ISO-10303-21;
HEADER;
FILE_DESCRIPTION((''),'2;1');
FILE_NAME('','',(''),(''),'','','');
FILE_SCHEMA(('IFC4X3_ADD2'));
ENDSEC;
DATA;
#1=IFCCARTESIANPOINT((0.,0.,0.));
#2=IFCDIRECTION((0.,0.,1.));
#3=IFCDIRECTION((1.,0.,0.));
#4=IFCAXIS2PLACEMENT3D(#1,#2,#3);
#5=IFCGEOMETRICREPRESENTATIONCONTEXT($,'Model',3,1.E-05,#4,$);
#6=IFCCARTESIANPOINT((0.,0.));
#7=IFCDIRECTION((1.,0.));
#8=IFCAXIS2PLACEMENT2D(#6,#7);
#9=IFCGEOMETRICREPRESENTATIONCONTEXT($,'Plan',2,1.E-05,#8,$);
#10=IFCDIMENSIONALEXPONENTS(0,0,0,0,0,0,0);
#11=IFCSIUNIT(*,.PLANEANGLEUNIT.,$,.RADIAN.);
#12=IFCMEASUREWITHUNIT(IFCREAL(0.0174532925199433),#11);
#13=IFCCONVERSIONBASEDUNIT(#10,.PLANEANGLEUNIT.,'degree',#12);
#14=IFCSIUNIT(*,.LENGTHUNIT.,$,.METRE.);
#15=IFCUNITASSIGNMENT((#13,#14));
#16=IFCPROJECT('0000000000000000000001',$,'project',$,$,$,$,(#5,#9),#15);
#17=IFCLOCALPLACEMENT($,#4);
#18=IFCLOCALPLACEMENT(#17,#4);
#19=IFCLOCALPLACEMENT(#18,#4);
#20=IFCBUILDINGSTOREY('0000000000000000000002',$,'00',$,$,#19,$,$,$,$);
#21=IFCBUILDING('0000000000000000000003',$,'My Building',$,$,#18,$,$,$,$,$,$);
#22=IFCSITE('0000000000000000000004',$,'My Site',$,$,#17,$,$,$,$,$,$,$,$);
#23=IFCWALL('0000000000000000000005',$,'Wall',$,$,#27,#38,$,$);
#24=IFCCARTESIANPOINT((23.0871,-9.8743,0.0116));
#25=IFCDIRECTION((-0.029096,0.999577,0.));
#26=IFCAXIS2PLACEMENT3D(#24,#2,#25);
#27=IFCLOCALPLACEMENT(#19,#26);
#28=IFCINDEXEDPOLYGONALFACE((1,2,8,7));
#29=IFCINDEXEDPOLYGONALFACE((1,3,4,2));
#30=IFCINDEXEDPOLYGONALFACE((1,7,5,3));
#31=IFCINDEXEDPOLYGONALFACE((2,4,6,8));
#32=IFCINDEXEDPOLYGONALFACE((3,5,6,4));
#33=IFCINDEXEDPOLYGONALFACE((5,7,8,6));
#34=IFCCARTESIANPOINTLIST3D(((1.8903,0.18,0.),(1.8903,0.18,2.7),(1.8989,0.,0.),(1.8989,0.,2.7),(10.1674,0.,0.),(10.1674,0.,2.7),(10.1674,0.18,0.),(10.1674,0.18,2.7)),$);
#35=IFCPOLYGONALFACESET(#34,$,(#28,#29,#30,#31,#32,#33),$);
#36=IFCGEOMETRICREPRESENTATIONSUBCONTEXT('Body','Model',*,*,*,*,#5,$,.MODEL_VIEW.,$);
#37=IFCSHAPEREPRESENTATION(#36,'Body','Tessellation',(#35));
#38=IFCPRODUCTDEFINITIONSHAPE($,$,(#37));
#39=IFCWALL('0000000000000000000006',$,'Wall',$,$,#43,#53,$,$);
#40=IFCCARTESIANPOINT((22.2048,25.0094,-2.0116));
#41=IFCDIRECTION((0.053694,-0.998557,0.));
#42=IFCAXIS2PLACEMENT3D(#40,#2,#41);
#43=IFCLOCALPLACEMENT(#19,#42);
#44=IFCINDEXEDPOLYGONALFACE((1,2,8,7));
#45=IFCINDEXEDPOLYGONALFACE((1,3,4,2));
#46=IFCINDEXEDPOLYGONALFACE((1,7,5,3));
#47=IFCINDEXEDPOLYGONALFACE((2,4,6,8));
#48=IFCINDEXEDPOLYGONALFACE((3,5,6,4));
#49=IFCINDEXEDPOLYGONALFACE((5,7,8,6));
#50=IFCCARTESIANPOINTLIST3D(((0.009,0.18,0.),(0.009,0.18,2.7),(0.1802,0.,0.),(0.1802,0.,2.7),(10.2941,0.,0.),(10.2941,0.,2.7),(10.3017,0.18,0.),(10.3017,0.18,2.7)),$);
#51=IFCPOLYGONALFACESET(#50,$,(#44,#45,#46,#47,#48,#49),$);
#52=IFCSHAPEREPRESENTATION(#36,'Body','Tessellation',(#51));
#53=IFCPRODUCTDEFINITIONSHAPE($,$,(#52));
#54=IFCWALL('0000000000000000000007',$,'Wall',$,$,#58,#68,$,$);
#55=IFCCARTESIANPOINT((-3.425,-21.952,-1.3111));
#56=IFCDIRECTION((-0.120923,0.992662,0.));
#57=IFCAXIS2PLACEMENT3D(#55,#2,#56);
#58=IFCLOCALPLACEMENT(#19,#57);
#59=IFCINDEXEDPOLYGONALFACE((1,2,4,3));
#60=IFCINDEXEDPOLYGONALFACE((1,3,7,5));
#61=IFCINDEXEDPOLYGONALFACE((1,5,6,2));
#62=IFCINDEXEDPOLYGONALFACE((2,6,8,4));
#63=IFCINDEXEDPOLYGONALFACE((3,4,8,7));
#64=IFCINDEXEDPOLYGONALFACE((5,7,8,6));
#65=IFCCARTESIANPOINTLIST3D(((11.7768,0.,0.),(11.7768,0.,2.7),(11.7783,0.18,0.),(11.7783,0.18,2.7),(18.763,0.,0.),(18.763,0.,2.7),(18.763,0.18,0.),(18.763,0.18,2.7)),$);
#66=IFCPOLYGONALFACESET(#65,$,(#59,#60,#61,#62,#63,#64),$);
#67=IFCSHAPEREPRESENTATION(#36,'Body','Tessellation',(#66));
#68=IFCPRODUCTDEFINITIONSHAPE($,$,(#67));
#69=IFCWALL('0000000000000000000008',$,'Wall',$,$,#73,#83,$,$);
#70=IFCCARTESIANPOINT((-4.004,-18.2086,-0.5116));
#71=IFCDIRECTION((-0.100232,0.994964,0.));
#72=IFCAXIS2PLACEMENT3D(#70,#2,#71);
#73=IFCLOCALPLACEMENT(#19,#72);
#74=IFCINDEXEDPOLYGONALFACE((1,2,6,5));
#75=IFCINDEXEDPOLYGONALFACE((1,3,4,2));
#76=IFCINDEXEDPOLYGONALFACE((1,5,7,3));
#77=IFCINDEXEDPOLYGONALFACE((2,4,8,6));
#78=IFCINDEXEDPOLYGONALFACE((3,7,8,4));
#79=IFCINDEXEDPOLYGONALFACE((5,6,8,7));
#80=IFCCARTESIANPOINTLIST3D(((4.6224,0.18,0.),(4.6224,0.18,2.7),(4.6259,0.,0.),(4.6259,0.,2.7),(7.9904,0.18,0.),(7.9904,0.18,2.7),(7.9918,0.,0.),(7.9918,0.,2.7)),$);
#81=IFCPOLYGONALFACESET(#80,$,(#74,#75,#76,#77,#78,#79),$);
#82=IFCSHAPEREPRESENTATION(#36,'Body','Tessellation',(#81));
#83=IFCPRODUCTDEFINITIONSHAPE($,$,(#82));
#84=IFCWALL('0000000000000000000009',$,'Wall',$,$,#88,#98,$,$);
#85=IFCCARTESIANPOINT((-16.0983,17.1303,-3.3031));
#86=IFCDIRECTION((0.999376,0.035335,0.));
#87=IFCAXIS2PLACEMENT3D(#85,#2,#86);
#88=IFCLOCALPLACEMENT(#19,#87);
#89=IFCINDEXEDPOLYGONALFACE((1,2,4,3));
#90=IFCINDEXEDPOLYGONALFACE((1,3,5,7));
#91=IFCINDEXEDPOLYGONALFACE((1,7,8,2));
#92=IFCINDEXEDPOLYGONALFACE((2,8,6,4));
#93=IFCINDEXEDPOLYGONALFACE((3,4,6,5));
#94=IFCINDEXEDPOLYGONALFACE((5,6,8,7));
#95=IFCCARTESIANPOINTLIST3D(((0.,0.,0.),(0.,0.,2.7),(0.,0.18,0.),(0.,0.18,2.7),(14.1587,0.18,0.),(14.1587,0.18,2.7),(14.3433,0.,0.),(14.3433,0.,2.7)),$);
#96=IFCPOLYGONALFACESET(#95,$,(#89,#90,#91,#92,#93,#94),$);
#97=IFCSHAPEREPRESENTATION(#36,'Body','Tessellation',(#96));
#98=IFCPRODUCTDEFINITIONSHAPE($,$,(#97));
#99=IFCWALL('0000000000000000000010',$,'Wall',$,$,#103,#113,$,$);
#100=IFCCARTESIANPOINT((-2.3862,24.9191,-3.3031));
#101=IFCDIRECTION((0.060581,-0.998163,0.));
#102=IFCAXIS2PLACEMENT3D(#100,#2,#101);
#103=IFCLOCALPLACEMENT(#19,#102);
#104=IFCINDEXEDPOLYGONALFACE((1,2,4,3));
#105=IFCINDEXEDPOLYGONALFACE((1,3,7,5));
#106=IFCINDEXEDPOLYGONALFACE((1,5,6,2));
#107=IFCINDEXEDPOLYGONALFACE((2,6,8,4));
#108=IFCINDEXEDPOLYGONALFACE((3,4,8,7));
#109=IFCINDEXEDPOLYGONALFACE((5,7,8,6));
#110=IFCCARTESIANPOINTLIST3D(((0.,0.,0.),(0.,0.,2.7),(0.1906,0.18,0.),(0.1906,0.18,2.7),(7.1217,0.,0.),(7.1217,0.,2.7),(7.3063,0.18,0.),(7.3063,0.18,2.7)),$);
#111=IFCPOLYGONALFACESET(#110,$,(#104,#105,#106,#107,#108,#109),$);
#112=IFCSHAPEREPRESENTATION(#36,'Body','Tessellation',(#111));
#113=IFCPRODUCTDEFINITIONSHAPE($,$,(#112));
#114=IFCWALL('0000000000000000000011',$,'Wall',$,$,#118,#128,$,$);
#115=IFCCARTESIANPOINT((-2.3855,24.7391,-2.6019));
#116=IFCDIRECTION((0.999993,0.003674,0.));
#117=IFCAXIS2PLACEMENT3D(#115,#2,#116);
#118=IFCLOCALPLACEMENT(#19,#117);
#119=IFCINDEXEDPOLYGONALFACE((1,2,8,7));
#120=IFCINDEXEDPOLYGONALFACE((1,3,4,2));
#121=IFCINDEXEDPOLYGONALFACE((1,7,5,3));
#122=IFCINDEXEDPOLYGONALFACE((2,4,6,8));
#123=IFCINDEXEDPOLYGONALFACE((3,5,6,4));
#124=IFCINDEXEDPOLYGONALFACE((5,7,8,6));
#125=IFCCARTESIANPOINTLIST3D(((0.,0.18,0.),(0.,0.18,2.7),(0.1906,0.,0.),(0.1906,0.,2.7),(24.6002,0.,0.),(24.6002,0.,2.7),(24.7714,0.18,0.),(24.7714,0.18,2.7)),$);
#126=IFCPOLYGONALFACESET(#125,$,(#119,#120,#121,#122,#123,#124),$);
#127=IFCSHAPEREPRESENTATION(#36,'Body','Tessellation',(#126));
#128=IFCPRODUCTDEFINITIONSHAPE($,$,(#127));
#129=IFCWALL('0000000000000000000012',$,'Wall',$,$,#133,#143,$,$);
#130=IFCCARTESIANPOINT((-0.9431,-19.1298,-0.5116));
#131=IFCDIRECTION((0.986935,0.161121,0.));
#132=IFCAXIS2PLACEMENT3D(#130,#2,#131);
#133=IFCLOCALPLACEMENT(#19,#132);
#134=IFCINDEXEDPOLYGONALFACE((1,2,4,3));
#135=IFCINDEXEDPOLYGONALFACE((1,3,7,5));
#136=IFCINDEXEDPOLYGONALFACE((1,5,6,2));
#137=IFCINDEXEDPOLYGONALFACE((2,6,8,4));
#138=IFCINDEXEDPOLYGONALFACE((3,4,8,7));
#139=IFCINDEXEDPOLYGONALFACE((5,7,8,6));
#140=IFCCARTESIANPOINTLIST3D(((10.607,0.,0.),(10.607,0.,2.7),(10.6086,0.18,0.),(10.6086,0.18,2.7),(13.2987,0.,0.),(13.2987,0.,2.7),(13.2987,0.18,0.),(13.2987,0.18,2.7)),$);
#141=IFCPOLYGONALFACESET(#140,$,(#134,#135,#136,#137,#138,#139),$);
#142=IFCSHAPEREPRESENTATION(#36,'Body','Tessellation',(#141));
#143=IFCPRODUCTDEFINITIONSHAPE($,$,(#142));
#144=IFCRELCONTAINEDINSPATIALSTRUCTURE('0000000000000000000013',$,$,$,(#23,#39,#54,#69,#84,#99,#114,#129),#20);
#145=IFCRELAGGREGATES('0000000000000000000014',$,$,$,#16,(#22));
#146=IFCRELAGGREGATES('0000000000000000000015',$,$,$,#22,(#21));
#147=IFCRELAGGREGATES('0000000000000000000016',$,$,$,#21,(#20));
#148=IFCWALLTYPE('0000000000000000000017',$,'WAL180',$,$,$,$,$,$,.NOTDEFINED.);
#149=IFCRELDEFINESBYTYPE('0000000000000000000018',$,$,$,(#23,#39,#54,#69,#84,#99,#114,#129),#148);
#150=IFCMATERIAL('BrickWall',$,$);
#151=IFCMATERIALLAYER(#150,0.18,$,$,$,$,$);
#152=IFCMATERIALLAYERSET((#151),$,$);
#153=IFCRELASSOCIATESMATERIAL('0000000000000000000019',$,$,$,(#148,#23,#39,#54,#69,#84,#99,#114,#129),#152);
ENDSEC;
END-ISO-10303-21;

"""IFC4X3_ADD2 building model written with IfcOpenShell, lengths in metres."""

from ifc_helpers import new_model, entity, si_unit, converted_unit, frame, origin_with_axes, origin_2d_with_axis, place, context, subcontext, project, spatial, indexed_curve, outline, extrude, clip, halfspace, material, layer, layer_set, layer_usage, type_object, element, save


model = new_model("IFC4X3_ADD2")

# Units and contexts
model_context = context("Model", 3, precision=1e-05, world=origin_with_axes())
plan_context = context("Plan", 2, precision=1e-05, world=origin_2d_with_axis())
body_context = subcontext(model_context, "Body", "Model", "MODEL_VIEW")
ifc_project = project(units=[converted_unit("PLANEANGLEUNIT", "degree", entity("IfcReal", 0.0174532925199433), si_unit("PLANEANGLEUNIT", "RADIAN"), dimensions=[0, 0, 0, 0, 0, 0, 0]), si_unit("LENGTHUNIT", "METRE")], contexts=[model_context, plan_context])

# Site, building, storey
site_placement = place(None, origin_with_axes())
site = spatial("IfcSite", under=ifc_project, at=site_placement, Name="My Site")
building_placement = place(site_placement, origin_with_axes())
building = spatial("IfcBuilding", under=site, at=building_placement, Name="My Building")
storey_placement = place(building_placement, origin_with_axes())
storey = spatial("IfcBuildingStorey", under=building, at=storey_placement, Name="00")

# Walls
ifc_material = material(Name="BrickWall")
ifc_layer = layer(ifc_material, 0.18)
ifc_layer_set = layer_set([ifc_layer])
wall_type = type_object("IfcWallType", Name="WAL180", PredefinedType="NOTDEFINED", material=ifc_layer_set)
ifc_layer_usage_1 = layer_usage(ifc_layer_set, "AXIS2", "POSITIVE", 0.0)
wall_1_placement = place(storey_placement, frame((23.0871, -9.8743, 0.0116), z_axis=(0.0, 0.0, 1.0), x_axis=(-0.029096, 0.999577, 0.0)))
element("IfcWall", 1, at=wall_1_placement, inside=storey, type_object=wall_type, material=ifc_layer_usage_1, Name="Wall", context=body_context, shape_type="Clipping", body=[
    clip(extrude(outline(indexed_curve([(0.0, 0.0), (0.0, 0.18), (10.1674, 0.18), (10.1674, 0.0), (0.0, 0.0)], self_intersect=False)), origin_with_axes(), (0.0, 0.0, 1.0), 2.7), halfspace(frame((1.8989, 0.0, -0.0116), z_axis=(-0.99887, -0.047523, 0.0), x_axis=(-0.047523, 0.99887, 0.0)), False)),
])
ifc_layer_usage_2 = layer_usage(ifc_layer_set, "AXIS2", "POSITIVE", 0.0)
wall_2_placement = place(storey_placement, frame((22.2048, 25.0094, -2.0116), z_axis=(0.0, 0.0, 1.0), x_axis=(0.053694, -0.998557, 0.0)))
element("IfcWall", 2, at=wall_2_placement, inside=storey, type_object=wall_type, material=ifc_layer_usage_2, Name="Wall", context=body_context, shape_type="Clipping", body=[
    clip(clip(extrude(outline(indexed_curve([(0.0, 0.0), (0.0, 0.18), (12.4301, 0.18), (12.4301, 0.0), (0.0, 0.0)], self_intersect=False)), origin_with_axes(), (0.0, 0.0, 1.0), 2.7), halfspace(frame((0.1802, 0.0, 2.0116), z_axis=(-0.724577, -0.689194, 0.0), x_axis=(-0.689194, 0.724577, 0.0)), False)), halfspace(frame((10.2941, 0.0, 2.0116), z_axis=(0.999108, -0.042241, 0.0), x_axis=(-0.042241, -0.999107, 0.0)), False)),
])
ifc_layer_usage_3 = layer_usage(ifc_layer_set, "AXIS2", "POSITIVE", 0.0)
wall_3_placement = place(storey_placement, frame((-3.425, -21.952, -1.3111), z_axis=(0.0, 0.0, 1.0), x_axis=(-0.120923, 0.992662, 0.0)))
element("IfcWall", 3, at=wall_3_placement, inside=storey, type_object=wall_type, material=ifc_layer_usage_3, Name="Wall", context=body_context, shape_type="Clipping", body=[
    clip(extrude(outline(indexed_curve([(0.0, 0.0), (0.0, 0.18), (18.763, 0.18), (18.763, 0.0), (0.0, 0.0)], self_intersect=False)), origin_with_axes(), (0.0, 0.0, 1.0), 2.7), halfspace(frame((11.7768, 0.0, 0.5116), z_axis=(-0.999969, 0.007908, 0.0), x_axis=(0.007908, 0.999969, 0.0)), False)),
])
ifc_layer_usage_4 = layer_usage(ifc_layer_set, "AXIS2", "POSITIVE", 0.0)
wall_4_placement = place(storey_placement, frame((-4.004, -18.2086, -0.5116), z_axis=(0.0, 0.0, 1.0), x_axis=(-0.100232, 0.994964, 0.0)))
element("IfcWall", 4, at=wall_4_placement, inside=storey, type_object=wall_type, material=ifc_layer_usage_4, Name="Wall", context=body_context, shape_type="Clipping", body=[
    clip(clip(extrude(outline(indexed_curve([(0.0, 0.0), (0.0, 0.18), (19.7687, 0.18), (19.7687, 0.0), (0.0, 0.0)], self_intersect=False)), origin_with_axes(), (0.0, 0.0, 1.0), 2.7), halfspace(frame((4.6259, 0.0, 0.5116), z_axis=(-0.99981, -0.019519, 0.0), x_axis=(-0.019519, 0.999809, 0.0)), False)), halfspace(frame((7.9918, 0.0, 0.5116), z_axis=(0.999972, 0.007553, 0.0), x_axis=(0.007553, -0.999971, 0.0)), False)),
])
ifc_layer_usage_5 = layer_usage(ifc_layer_set, "AXIS2", "POSITIVE", 0.0)
wall_5_placement = place(storey_placement, frame((-16.0983, 17.1303, -3.3031), z_axis=(0.0, 0.0, 1.0), x_axis=(0.999376, 0.035335, 0.0)))
element("IfcWall", 5, at=wall_5_placement, inside=storey, type_object=wall_type, material=ifc_layer_usage_5, Name="Wall", context=body_context, shape_type="Clipping", body=[
    clip(extrude(outline(indexed_curve([(0.0, 0.0), (0.0, 0.18), (14.3433, 0.18), (14.3433, 0.0), (0.0, 0.0)], self_intersect=False)), origin_with_axes(), (0.0, 0.0, 1.0), 2.7), halfspace(frame((14.3433, 0.0, 2.6019), z_axis=(0.698115, 0.715986, 0.0), x_axis=(0.715986, -0.698114, 0.0)), False)),
])
ifc_layer_usage_6 = layer_usage(ifc_layer_set, "AXIS2", "POSITIVE", 0.0)
wall_6_placement = place(storey_placement, frame((-2.3862, 24.9191, -3.3031), z_axis=(0.0, 0.0, 1.0), x_axis=(0.060581, -0.998163, 0.0)))
element("IfcWall", 6, at=wall_6_placement, inside=storey, type_object=wall_type, material=ifc_layer_usage_6, Name="Wall", context=body_context, shape_type="Clipping", body=[
    clip(clip(extrude(outline(indexed_curve([(0.0, 0.0), (0.0, 0.18), (7.3063, 0.18), (7.3063, 0.0), (0.0, 0.0)], self_intersect=False)), origin_with_axes(), (0.0, 0.0, 1.0), 2.7), halfspace(frame((0.0, 0.0, 2.6019), z_axis=(-0.686695, 0.726946, 0.0), x_axis=(0.726946, 0.686695, 0.0)), False)), halfspace(frame((7.1217, 0.0, 2.6019), z_axis=(0.698115, -0.715986, 0.0), x_axis=(-0.715986, -0.698115, 0.0)), False)),
])
ifc_layer_usage_7 = layer_usage(ifc_layer_set, "AXIS2", "POSITIVE", 0.0)
wall_7_placement = place(storey_placement, frame((-2.3855, 24.7391, -2.6019), z_axis=(0.0, 0.0, 1.0), x_axis=(0.999993, 0.003674, 0.0)))
element("IfcWall", 7, at=wall_7_placement, inside=storey, type_object=wall_type, material=ifc_layer_usage_7, Name="Wall", context=body_context, shape_type="Clipping", body=[
    clip(clip(extrude(outline(indexed_curve([(0.0, 0.0), (0.0, 0.18), (24.7804, 0.18), (24.7804, 0.0), (0.0, 0.0)], self_intersect=False)), origin_with_axes(), (0.0, 0.0, 1.0), 2.7), halfspace(frame((0.1906, 0.0, 2.6019), z_axis=(-0.686687, -0.726954, 0.0), x_axis=(-0.726953, 0.686687, 0.0)), False)), halfspace(frame((24.6002, 0.0, 2.6019), z_axis=(0.724574, -0.689198, 0.0), x_axis=(-0.689198, -0.724573, 0.0)), False)),
])
ifc_layer_usage_8 = layer_usage(ifc_layer_set, "AXIS2", "POSITIVE", 0.0)
wall_8_placement = place(storey_placement, frame((-0.9431, -19.1298, -0.5116), z_axis=(0.0, 0.0, 1.0), x_axis=(0.986935, 0.161121, 0.0)))
element("IfcWall", 8, at=wall_8_placement, inside=storey, type_object=wall_type, material=ifc_layer_usage_8, Name="Wall", context=body_context, shape_type="Clipping", body=[
    clip(extrude(outline(indexed_curve([(0.0, 0.0), (0.0, 0.18), (13.2987, 0.18), (13.2987, 0.0), (0.0, 0.0)], self_intersect=False)), origin_with_axes(), (0.0, 0.0, 1.0), 2.7), halfspace(frame((10.607, 0.0, 0.5116), z_axis=(-0.999961, 0.008825, 0.0), x_axis=(0.008825, 0.999961, 0.0)), False)),
])

save(model, "model.ifc")
